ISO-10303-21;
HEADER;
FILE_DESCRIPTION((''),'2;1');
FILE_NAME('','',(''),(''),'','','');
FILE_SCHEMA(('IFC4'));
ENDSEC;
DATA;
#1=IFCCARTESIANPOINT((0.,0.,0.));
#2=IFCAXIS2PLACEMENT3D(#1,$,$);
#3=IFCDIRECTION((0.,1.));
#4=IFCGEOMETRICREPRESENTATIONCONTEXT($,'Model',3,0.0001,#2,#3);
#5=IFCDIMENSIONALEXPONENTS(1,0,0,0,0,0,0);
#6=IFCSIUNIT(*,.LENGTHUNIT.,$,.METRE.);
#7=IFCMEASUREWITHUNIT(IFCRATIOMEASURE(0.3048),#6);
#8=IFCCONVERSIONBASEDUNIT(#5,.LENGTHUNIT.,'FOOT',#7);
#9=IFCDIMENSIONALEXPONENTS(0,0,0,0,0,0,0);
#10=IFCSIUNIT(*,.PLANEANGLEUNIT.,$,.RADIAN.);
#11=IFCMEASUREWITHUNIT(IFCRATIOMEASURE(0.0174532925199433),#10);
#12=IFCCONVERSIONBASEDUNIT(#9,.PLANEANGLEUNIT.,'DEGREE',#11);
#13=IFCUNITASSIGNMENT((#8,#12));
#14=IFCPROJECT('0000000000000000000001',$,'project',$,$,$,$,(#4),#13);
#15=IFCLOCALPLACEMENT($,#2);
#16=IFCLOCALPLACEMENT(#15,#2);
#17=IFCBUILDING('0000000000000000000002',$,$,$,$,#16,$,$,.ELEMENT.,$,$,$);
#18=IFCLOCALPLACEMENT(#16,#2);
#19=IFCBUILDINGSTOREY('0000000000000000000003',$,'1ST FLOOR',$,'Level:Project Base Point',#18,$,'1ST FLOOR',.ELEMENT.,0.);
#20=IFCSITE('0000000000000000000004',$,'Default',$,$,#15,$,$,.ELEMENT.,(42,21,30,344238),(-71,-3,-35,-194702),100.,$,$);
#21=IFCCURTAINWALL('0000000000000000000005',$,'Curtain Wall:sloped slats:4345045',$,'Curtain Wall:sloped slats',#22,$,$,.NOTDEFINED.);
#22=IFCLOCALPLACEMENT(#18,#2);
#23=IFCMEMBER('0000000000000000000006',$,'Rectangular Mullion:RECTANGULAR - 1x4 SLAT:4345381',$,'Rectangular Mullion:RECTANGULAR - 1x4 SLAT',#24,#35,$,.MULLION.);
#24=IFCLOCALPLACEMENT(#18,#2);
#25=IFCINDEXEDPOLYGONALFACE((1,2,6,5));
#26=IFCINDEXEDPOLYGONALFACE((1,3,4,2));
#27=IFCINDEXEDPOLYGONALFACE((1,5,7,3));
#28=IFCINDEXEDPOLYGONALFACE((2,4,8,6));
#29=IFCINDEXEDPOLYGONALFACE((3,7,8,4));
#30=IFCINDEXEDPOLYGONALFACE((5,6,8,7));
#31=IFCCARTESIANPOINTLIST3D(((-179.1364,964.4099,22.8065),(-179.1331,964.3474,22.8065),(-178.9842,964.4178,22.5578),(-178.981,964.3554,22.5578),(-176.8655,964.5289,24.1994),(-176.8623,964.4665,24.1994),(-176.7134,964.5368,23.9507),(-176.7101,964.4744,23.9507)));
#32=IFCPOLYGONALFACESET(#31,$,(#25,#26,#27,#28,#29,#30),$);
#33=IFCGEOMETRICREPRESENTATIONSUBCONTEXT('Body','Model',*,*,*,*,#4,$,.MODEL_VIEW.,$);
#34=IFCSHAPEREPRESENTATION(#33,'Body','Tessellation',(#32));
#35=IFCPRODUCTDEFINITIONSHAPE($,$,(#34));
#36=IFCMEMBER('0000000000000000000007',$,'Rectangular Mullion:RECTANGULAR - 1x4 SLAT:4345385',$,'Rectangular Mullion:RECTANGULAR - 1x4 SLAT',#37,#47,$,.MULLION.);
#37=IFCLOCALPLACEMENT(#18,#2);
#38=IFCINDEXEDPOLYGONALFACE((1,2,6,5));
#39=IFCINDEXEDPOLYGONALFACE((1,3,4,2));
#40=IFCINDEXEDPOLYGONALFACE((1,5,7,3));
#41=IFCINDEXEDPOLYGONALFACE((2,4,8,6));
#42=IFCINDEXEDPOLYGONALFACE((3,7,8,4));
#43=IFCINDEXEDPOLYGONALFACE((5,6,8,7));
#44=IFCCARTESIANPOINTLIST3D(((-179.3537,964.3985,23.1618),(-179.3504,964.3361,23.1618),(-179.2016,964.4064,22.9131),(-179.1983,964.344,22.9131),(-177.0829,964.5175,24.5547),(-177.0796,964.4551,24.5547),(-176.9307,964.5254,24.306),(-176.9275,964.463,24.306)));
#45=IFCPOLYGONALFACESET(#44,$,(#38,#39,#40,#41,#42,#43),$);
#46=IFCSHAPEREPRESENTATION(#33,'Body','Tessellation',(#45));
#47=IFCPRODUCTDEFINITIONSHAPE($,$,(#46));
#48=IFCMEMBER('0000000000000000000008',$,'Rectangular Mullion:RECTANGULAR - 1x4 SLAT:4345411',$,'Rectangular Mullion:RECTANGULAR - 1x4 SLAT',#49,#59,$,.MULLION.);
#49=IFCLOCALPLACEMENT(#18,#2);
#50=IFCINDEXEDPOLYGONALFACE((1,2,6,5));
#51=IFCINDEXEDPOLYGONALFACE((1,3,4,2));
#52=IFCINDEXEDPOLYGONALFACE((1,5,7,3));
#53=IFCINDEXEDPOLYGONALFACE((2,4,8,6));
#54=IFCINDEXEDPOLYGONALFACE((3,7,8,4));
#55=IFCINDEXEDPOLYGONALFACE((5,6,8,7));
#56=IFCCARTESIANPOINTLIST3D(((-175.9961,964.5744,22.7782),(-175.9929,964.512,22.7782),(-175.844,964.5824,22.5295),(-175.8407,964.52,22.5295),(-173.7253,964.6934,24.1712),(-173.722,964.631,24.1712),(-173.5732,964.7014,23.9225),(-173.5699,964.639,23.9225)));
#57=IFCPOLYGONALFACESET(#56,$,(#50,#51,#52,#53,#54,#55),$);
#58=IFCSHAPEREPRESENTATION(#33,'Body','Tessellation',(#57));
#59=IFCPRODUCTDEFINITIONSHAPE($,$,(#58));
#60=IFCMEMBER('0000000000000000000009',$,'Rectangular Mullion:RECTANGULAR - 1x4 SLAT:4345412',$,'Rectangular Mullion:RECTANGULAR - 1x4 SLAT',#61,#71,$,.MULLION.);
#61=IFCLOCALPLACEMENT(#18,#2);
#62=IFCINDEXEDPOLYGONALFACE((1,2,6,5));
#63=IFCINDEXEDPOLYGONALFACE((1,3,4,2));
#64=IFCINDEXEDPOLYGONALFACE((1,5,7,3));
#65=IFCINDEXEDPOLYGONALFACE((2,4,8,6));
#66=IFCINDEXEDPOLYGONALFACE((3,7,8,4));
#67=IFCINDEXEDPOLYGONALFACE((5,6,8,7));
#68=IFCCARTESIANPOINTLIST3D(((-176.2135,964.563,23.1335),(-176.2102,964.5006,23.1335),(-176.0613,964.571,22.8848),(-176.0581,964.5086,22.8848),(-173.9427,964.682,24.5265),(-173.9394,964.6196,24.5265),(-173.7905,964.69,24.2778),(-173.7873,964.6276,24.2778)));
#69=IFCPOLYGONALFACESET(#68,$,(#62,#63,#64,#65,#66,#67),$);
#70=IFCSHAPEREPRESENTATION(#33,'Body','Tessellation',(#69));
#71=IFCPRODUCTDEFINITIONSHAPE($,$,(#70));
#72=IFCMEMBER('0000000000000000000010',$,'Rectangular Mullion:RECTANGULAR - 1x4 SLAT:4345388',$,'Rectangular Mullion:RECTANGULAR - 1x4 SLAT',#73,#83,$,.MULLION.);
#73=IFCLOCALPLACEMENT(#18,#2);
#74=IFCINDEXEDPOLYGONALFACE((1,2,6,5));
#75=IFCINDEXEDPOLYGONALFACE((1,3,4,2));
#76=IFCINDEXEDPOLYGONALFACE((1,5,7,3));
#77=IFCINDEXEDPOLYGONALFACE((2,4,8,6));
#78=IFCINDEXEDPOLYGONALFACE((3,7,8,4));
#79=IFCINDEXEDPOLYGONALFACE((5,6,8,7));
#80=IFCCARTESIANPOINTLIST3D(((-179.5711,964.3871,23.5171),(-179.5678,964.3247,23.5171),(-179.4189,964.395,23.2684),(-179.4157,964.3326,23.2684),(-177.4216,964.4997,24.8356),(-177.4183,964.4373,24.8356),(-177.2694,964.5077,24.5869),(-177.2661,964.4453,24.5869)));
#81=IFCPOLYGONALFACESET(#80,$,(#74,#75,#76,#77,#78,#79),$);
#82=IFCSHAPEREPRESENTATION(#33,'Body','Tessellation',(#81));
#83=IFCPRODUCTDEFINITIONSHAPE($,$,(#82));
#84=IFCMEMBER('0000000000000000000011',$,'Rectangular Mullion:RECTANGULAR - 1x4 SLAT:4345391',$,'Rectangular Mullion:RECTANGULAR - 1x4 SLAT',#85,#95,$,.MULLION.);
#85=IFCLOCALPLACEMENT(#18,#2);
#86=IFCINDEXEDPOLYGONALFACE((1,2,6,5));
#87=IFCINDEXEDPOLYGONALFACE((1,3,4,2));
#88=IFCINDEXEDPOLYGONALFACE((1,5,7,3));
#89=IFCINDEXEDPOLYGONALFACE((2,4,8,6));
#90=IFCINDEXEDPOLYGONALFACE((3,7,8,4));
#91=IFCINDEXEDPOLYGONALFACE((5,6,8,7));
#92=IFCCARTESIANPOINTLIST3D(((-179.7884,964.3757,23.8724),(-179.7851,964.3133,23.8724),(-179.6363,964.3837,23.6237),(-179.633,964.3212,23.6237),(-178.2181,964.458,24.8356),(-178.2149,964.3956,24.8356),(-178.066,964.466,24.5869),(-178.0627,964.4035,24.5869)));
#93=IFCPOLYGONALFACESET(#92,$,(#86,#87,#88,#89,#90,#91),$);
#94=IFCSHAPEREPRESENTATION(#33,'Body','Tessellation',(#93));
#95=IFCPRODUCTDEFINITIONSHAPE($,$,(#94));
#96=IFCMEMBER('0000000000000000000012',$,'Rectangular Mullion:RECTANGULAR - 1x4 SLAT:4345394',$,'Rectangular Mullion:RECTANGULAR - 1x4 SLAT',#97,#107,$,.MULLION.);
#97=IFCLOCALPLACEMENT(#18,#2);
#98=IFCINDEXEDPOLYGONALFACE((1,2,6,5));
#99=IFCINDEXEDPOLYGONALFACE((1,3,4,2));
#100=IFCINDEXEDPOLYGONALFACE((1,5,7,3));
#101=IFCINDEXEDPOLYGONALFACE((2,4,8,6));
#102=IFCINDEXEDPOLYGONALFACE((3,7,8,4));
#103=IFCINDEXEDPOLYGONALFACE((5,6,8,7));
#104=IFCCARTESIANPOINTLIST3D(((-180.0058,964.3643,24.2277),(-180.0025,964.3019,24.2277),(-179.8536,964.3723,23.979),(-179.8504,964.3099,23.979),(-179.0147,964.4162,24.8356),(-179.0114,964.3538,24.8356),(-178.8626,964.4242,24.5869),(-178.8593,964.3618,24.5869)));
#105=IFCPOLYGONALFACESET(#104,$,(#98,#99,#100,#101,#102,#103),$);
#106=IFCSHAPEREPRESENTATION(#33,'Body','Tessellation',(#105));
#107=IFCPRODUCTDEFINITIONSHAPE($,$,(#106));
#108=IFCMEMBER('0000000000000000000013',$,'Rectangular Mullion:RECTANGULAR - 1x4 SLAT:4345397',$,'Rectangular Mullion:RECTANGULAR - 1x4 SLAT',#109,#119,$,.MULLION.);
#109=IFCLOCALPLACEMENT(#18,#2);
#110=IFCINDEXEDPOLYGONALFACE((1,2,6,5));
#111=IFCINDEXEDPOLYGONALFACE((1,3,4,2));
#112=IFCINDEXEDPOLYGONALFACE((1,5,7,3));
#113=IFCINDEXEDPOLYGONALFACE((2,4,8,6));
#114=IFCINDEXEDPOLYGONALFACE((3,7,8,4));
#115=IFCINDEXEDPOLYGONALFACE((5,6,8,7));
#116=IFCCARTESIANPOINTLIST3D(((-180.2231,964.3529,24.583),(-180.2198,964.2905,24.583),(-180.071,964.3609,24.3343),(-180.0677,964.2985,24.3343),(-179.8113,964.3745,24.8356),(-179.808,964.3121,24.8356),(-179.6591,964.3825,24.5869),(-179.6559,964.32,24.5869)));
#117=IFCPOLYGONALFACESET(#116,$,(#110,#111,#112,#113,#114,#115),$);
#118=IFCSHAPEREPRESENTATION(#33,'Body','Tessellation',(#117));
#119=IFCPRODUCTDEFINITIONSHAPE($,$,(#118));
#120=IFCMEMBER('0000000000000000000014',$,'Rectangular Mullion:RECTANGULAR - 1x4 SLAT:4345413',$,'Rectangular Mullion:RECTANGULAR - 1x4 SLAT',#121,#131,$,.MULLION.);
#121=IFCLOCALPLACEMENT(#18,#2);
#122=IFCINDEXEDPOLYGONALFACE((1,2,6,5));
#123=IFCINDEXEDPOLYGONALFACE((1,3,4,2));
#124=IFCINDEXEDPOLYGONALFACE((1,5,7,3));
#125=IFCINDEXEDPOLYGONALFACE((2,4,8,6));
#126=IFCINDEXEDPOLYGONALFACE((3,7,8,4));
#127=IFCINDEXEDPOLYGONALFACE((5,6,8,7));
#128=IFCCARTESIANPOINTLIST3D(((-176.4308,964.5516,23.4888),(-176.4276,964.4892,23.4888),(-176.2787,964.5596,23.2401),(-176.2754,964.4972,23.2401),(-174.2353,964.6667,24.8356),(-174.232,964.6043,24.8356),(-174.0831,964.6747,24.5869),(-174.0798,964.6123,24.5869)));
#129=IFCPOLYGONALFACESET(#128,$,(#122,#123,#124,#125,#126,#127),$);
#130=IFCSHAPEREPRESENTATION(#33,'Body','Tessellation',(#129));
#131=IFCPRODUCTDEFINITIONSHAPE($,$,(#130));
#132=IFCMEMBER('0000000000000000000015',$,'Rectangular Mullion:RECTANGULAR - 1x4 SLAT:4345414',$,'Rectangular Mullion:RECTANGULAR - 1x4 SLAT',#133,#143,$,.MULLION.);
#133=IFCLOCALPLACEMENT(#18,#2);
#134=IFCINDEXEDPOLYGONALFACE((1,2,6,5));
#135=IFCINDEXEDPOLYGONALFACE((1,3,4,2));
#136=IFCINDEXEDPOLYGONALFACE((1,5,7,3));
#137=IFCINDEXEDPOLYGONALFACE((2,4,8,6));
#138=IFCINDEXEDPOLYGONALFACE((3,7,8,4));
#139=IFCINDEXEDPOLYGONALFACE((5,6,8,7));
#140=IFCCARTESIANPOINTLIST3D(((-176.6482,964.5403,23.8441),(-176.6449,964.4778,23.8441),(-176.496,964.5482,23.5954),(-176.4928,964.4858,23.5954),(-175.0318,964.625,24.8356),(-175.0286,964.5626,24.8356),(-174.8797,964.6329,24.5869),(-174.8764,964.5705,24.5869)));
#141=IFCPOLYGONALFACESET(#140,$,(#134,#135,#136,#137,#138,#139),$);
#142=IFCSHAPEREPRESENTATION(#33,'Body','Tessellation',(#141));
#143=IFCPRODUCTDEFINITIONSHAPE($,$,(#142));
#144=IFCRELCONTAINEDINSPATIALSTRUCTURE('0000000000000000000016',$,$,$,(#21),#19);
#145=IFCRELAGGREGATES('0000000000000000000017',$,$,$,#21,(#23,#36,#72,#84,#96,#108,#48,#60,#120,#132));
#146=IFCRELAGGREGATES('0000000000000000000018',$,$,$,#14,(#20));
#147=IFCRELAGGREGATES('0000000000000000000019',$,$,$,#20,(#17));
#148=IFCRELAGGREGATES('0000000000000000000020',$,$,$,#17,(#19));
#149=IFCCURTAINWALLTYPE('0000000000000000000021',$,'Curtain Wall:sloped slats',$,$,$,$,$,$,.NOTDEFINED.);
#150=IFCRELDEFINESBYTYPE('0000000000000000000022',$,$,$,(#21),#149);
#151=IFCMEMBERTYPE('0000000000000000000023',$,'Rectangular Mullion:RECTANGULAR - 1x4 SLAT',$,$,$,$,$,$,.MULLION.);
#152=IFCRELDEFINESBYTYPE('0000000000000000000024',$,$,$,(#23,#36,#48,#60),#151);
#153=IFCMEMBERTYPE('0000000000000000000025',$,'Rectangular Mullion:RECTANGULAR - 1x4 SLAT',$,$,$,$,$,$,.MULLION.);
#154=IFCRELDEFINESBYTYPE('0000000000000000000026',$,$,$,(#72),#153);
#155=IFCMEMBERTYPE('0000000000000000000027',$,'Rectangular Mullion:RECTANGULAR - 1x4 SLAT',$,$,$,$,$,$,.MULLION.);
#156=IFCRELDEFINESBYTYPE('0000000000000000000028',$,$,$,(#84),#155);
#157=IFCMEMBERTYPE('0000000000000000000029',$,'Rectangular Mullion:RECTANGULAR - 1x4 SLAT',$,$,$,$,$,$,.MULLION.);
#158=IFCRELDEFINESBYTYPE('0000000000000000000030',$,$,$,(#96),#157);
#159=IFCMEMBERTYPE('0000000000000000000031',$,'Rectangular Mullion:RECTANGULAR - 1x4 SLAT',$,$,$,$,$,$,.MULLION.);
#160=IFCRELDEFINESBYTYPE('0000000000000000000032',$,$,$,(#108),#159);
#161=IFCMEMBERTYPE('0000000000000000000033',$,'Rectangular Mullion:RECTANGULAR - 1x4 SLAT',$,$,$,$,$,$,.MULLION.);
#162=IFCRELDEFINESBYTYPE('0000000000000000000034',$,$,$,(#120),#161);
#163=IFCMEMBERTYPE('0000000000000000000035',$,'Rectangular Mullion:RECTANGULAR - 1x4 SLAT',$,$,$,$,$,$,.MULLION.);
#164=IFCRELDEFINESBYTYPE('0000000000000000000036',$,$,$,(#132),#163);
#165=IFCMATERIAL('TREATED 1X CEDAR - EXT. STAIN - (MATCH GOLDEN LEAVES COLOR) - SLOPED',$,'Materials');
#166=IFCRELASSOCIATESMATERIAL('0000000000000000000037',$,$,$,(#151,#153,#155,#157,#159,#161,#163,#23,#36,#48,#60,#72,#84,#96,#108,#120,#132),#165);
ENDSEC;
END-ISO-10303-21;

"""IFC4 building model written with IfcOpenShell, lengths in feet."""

from ifc_helpers import new_model, entity, si_unit, converted_unit, direction, frame, frame_2d, origin, origin_2d_with_axis, place, context, subcontext, project, spatial, rectangle, extrude, source, transform, mapped, material, material_profile, profile_set, profile_usage, type_object, type_shapes, element, aggregate, save


model = new_model("IFC4")

# Units and contexts
model_context = context("Model", 3, precision=0.0001, world=origin(), true_north=direction((0.0, 1.0)))
body_context = subcontext(model_context, "Body", "Model", "MODEL_VIEW")
ifc_project = project(units=[converted_unit("LENGTHUNIT", "FOOT", entity("IfcRatioMeasure", 0.3048), si_unit("LENGTHUNIT", "METRE"), dimensions=[1, 0, 0, 0, 0, 0, 0]), converted_unit("PLANEANGLEUNIT", "DEGREE", entity("IfcRatioMeasure", 0.0174532925199433), si_unit("PLANEANGLEUNIT", "RADIAN"), dimensions=[0, 0, 0, 0, 0, 0, 0])], contexts=[model_context])

# Site, building, storey
site_placement = place(None, origin())
site = spatial("IfcSite", under=ifc_project, at=site_placement, Name="Default", CompositionType="ELEMENT", RefLatitude=(42, 21, 30, 344238), RefLongitude=(-71, -3, -35, -194702), RefElevation=100.0)
building_placement = place(site_placement, origin())
building = spatial("IfcBuilding", under=site, at=building_placement, CompositionType="ELEMENT")
storey_placement = place(building_placement, origin())
storey = spatial("IfcBuildingStorey", under=building, at=storey_placement, Name="1ST FLOOR", ObjectType="Level:Project Base Point", LongName="1ST FLOOR", CompositionType="ELEMENT", Elevation=0.0)

# Curtain wall, members
curtain_wall_type_1 = type_object("IfcCurtainWallType", Name="Curtain Wall:sloped slats", PredefinedType="NOTDEFINED")
curtain_wall_1_placement = place(storey_placement, origin())
curtain_wall_1 = element("IfcCurtainWall", 1, at=curtain_wall_1_placement, inside=storey, type_object=curtain_wall_type_1, Name="Curtain Wall:sloped slats:4345045", ObjectType="Curtain Wall:sloped slats", PredefinedType="NOTDEFINED")
ifc_material_1 = material(Name="TREATED 1X CEDAR - EXT. STAIN - (MATCH GOLDEN LEAVES COLOR) - SLOPED", Category="Materials")
ifc_material_profile_1 = material_profile(ifc_material_1, rectangle(XDim=0.0625, YDim=0.2917, at=frame_2d((0.0, 0.0), x_axis=(1.0, 0.0))), Name="RECTANGULAR - 1x4 SLAT")
ifc_profile_set_1 = profile_set([ifc_material_profile_1], Name="RECTANGULAR - 1x4 SLAT")
ifc_profile_usage_1 = profile_usage(ifc_profile_set_1)
member_type_1 = type_object("IfcMemberType", Name="Rectangular Mullion:RECTANGULAR - 1x4 SLAT", PredefinedType="MULLION", material=ifc_profile_set_1)
shared_shape_1 = source(origin(), body_context, "Body", "SweptSolid", [
    extrude(rectangle(XDim=0.0625, YDim=0.2917, at=frame_2d((0.0, 0.0), x_axis=(1.0, 0.0))), frame((0.0, 0.0, -2.6667), z_axis=(0.0, 0.0, 1.0), x_axis=(0.0, -1.0, 0.0)), (0.0, 0.0, 1.0), 2.6667),
])
type_shapes(member_type_1, [shared_shape_1])
member_1_placement = place(storey_placement, frame((-179.0587, 964.3826, 22.6821), z_axis=(-0.851559, -0.044628, -0.522356), x_axis=(-0.52164, -0.027338, 0.852727)))
member_1 = element("IfcMember", 2, at=member_1_placement, type_object=member_type_1, material=ifc_profile_usage_1, Name="Rectangular Mullion:RECTANGULAR - 1x4 SLAT:4345381", ObjectType="Rectangular Mullion:RECTANGULAR - 1x4 SLAT", PredefinedType="MULLION", context=body_context, shape_type="MappedRepresentation", body=[
    mapped(shared_shape_1, transform((0.0, 0.0, 0.0), scale=1.0)),
])
ifc_profile_usage_2 = profile_usage(ifc_profile_set_1)
member_2_placement = place(storey_placement, frame((-179.276, 964.3712, 23.0374), z_axis=(-0.851559, -0.044628, -0.522356), x_axis=(-0.52164, -0.027338, 0.852727)))
member_2 = element("IfcMember", 3, at=member_2_placement, type_object=member_type_1, material=ifc_profile_usage_2, Name="Rectangular Mullion:RECTANGULAR - 1x4 SLAT:4345385", ObjectType="Rectangular Mullion:RECTANGULAR - 1x4 SLAT", PredefinedType="MULLION", context=body_context, shape_type="MappedRepresentation", body=[
    mapped(shared_shape_1, transform((0.0, 0.0, 0.0), scale=1.0)),
])
ifc_profile_usage_3 = profile_usage(ifc_profile_set_1)
member_3_placement = place(storey_placement, frame((-175.9184, 964.5472, 22.6539), z_axis=(-0.851559, -0.044628, -0.522356), x_axis=(-0.52164, -0.027338, 0.852727)))
member_3 = element("IfcMember", 4, at=member_3_placement, type_object=member_type_1, material=ifc_profile_usage_3, Name="Rectangular Mullion:RECTANGULAR - 1x4 SLAT:4345411", ObjectType="Rectangular Mullion:RECTANGULAR - 1x4 SLAT", PredefinedType="MULLION", context=body_context, shape_type="MappedRepresentation", body=[
    mapped(shared_shape_1, transform((0.0, 0.0, 0.0), scale=1.0)),
])
ifc_profile_usage_4 = profile_usage(ifc_profile_set_1)
member_4_placement = place(storey_placement, frame((-176.1358, 964.5358, 23.0092), z_axis=(-0.851559, -0.044628, -0.522356), x_axis=(-0.52164, -0.027338, 0.852727)))
member_4 = element("IfcMember", 5, at=member_4_placement, type_object=member_type_1, material=ifc_profile_usage_4, Name="Rectangular Mullion:RECTANGULAR - 1x4 SLAT:4345412", ObjectType="Rectangular Mullion:RECTANGULAR - 1x4 SLAT", PredefinedType="MULLION", context=body_context, shape_type="MappedRepresentation", body=[
    mapped(shared_shape_1, transform((0.0, 0.0, 0.0), scale=1.0)),
])
ifc_profile_usage_5 = profile_usage(ifc_profile_set_1)
member_type_2 = type_object("IfcMemberType", Name="Rectangular Mullion:RECTANGULAR - 1x4 SLAT", PredefinedType="MULLION", material=ifc_profile_set_1)
shared_shape_2 = source(origin(), body_context, "Body", "SweptSolid", [
    extrude(rectangle(XDim=0.0625, YDim=0.2917, at=frame_2d((0.0, 0.0), x_axis=(1.0, 0.0))), frame((0.0, 0.0, -2.5242), z_axis=(0.0, 0.0, 1.0), x_axis=(0.0, -1.0, 0.0)), (0.0, 0.0, 1.0), 2.5242),
])
type_shapes(member_type_2, [shared_shape_2])
member_5_placement = place(storey_placement, frame((-179.4934, 964.3599, 23.3927), z_axis=(-0.851559, -0.044628, -0.522356), x_axis=(-0.52164, -0.027338, 0.852727)))
member_5 = element("IfcMember", 6, at=member_5_placement, type_object=member_type_2, material=ifc_profile_usage_5, Name="Rectangular Mullion:RECTANGULAR - 1x4 SLAT:4345388", ObjectType="Rectangular Mullion:RECTANGULAR - 1x4 SLAT", PredefinedType="MULLION", context=body_context, shape_type="MappedRepresentation", body=[
    mapped(shared_shape_2, transform((0.0, 0.0, 0.0), scale=1.0)),
])
ifc_profile_usage_6 = profile_usage(ifc_profile_set_1)
member_type_3 = type_object("IfcMemberType", Name="Rectangular Mullion:RECTANGULAR - 1x4 SLAT", PredefinedType="MULLION", material=ifc_profile_set_1)
shared_shape_3 = source(origin(), body_context, "Body", "SweptSolid", [
    extrude(rectangle(XDim=0.0625, YDim=0.2917, at=origin_2d_with_axis()), frame((0.0, 0.0, -1.844), z_axis=(0.0, 0.0, 1.0), x_axis=(0.0, -1.0, 0.0)), (0.0, 0.0, 1.0), 1.844),
])
type_shapes(member_type_3, [shared_shape_3])
member_6_placement = place(storey_placement, frame((-179.7107, 964.3485, 23.748), z_axis=(-0.851559, -0.044628, -0.522356), x_axis=(-0.52164, -0.027338, 0.852727)))
member_6 = element("IfcMember", 7, at=member_6_placement, type_object=member_type_3, material=ifc_profile_usage_6, Name="Rectangular Mullion:RECTANGULAR - 1x4 SLAT:4345391", ObjectType="Rectangular Mullion:RECTANGULAR - 1x4 SLAT", PredefinedType="MULLION", context=body_context, shape_type="MappedRepresentation", body=[
    mapped(shared_shape_3, transform((0.0, 0.0, 0.0), scale=1.0)),
])
ifc_profile_usage_7 = profile_usage(ifc_profile_set_1)
member_type_4 = type_object("IfcMemberType", Name="Rectangular Mullion:RECTANGULAR - 1x4 SLAT", PredefinedType="MULLION", material=ifc_profile_set_1)
shared_shape_4 = source(origin(), body_context, "Body", "SweptSolid", [
    extrude(rectangle(XDim=0.0625, YDim=0.2917, at=frame_2d((0.0, 0.0), x_axis=(1.0, 0.0))), frame((0.0, 0.0, -1.1638), z_axis=(0.0, 0.0, 1.0), x_axis=(0.0, -1.0, 0.0)), (0.0, 0.0, 1.0), 1.1638),
])
type_shapes(member_type_4, [shared_shape_4])
member_7_placement = place(storey_placement, frame((-179.9281, 964.3371, 24.1033), z_axis=(-0.851559, -0.044628, -0.522356), x_axis=(-0.52164, -0.027338, 0.852727)))
member_7 = element("IfcMember", 8, at=member_7_placement, type_object=member_type_4, material=ifc_profile_usage_7, Name="Rectangular Mullion:RECTANGULAR - 1x4 SLAT:4345394", ObjectType="Rectangular Mullion:RECTANGULAR - 1x4 SLAT", PredefinedType="MULLION", context=body_context, shape_type="MappedRepresentation", body=[
    mapped(shared_shape_4, transform((0.0, 0.0, 0.0), scale=1.0)),
])
ifc_profile_usage_8 = profile_usage(ifc_profile_set_1)
member_type_5 = type_object("IfcMemberType", Name="Rectangular Mullion:RECTANGULAR - 1x4 SLAT", PredefinedType="MULLION", material=ifc_profile_set_1)
shared_shape_5 = source(origin(), body_context, "Body", "SweptSolid", [
    extrude(rectangle(XDim=0.0625, YDim=0.2917, at=origin_2d_with_axis()), frame((0.0, 0.0, -0.4836), z_axis=(0.0, 0.0, 1.0), x_axis=(0.0, -1.0, 0.0)), (0.0, 0.0, 1.0), 0.4836),
])
type_shapes(member_type_5, [shared_shape_5])
member_8_placement = place(storey_placement, frame((-180.1454, 964.3257, 24.4586), z_axis=(-0.851559, -0.044628, -0.522356), x_axis=(-0.52164, -0.027338, 0.852727)))
member_8 = element("IfcMember", 9, at=member_8_placement, type_object=member_type_5, material=ifc_profile_usage_8, Name="Rectangular Mullion:RECTANGULAR - 1x4 SLAT:4345397", ObjectType="Rectangular Mullion:RECTANGULAR - 1x4 SLAT", PredefinedType="MULLION", context=body_context, shape_type="MappedRepresentation", body=[
    mapped(shared_shape_5, transform((0.0, 0.0, 0.0), scale=1.0)),
])
ifc_profile_usage_9 = profile_usage(ifc_profile_set_1)
member_type_6 = type_object("IfcMemberType", Name="Rectangular Mullion:RECTANGULAR - 1x4 SLAT", PredefinedType="MULLION", material=ifc_profile_set_1)
shared_shape_6 = source(origin(), body_context, "Body", "SweptSolid", [
    extrude(rectangle(XDim=0.0625, YDim=0.2917, at=frame_2d((0.0, 0.0), x_axis=(1.0, 0.0))), frame((0.0, 0.0, -2.5783), z_axis=(0.0, 0.0, 1.0), x_axis=(0.0, -1.0, 0.0)), (0.0, 0.0, 1.0), 2.5783),
])
type_shapes(member_type_6, [shared_shape_6])
member_9_placement = place(storey_placement, frame((-176.3531, 964.5244, 23.3645), z_axis=(-0.851559, -0.044628, -0.522356), x_axis=(-0.52164, -0.027338, 0.852727)))
member_9 = element("IfcMember", 10, at=member_9_placement, type_object=member_type_6, material=ifc_profile_usage_9, Name="Rectangular Mullion:RECTANGULAR - 1x4 SLAT:4345413", ObjectType="Rectangular Mullion:RECTANGULAR - 1x4 SLAT", PredefinedType="MULLION", context=body_context, shape_type="MappedRepresentation", body=[
    mapped(shared_shape_6, transform((0.0, 0.0, 0.0), scale=1.0)),
])
ifc_profile_usage_10 = profile_usage(ifc_profile_set_1)
member_type_7 = type_object("IfcMemberType", Name="Rectangular Mullion:RECTANGULAR - 1x4 SLAT", PredefinedType="MULLION", material=ifc_profile_set_1)
shared_shape_7 = source(origin(), body_context, "Body", "SweptSolid", [
    extrude(rectangle(XDim=0.0625, YDim=0.2917, at=frame_2d((0.0, 0.0), x_axis=(1.0, 0.0))), frame((0.0, 0.0, -1.8981), z_axis=(0.0, 0.0, 1.0), x_axis=(0.0, -1.0, 0.0)), (0.0, 0.0, 1.0), 1.8981),
])
type_shapes(member_type_7, [shared_shape_7])
member_10_placement = place(storey_placement, frame((-176.5705, 964.513, 23.7198), z_axis=(-0.851559, -0.044628, -0.522356), x_axis=(-0.52164, -0.027338, 0.852727)))
member_10 = element("IfcMember", 11, at=member_10_placement, type_object=member_type_7, material=ifc_profile_usage_10, Name="Rectangular Mullion:RECTANGULAR - 1x4 SLAT:4345414", ObjectType="Rectangular Mullion:RECTANGULAR - 1x4 SLAT", PredefinedType="MULLION", context=body_context, shape_type="MappedRepresentation", body=[
    mapped(shared_shape_7, transform((0.0, 0.0, 0.0), scale=1.0)),
])
aggregate(curtain_wall_1, [member_1, member_2, member_5, member_6, member_7, member_8, member_3, member_4, member_9, member_10])

save(model, "model.ifc")
